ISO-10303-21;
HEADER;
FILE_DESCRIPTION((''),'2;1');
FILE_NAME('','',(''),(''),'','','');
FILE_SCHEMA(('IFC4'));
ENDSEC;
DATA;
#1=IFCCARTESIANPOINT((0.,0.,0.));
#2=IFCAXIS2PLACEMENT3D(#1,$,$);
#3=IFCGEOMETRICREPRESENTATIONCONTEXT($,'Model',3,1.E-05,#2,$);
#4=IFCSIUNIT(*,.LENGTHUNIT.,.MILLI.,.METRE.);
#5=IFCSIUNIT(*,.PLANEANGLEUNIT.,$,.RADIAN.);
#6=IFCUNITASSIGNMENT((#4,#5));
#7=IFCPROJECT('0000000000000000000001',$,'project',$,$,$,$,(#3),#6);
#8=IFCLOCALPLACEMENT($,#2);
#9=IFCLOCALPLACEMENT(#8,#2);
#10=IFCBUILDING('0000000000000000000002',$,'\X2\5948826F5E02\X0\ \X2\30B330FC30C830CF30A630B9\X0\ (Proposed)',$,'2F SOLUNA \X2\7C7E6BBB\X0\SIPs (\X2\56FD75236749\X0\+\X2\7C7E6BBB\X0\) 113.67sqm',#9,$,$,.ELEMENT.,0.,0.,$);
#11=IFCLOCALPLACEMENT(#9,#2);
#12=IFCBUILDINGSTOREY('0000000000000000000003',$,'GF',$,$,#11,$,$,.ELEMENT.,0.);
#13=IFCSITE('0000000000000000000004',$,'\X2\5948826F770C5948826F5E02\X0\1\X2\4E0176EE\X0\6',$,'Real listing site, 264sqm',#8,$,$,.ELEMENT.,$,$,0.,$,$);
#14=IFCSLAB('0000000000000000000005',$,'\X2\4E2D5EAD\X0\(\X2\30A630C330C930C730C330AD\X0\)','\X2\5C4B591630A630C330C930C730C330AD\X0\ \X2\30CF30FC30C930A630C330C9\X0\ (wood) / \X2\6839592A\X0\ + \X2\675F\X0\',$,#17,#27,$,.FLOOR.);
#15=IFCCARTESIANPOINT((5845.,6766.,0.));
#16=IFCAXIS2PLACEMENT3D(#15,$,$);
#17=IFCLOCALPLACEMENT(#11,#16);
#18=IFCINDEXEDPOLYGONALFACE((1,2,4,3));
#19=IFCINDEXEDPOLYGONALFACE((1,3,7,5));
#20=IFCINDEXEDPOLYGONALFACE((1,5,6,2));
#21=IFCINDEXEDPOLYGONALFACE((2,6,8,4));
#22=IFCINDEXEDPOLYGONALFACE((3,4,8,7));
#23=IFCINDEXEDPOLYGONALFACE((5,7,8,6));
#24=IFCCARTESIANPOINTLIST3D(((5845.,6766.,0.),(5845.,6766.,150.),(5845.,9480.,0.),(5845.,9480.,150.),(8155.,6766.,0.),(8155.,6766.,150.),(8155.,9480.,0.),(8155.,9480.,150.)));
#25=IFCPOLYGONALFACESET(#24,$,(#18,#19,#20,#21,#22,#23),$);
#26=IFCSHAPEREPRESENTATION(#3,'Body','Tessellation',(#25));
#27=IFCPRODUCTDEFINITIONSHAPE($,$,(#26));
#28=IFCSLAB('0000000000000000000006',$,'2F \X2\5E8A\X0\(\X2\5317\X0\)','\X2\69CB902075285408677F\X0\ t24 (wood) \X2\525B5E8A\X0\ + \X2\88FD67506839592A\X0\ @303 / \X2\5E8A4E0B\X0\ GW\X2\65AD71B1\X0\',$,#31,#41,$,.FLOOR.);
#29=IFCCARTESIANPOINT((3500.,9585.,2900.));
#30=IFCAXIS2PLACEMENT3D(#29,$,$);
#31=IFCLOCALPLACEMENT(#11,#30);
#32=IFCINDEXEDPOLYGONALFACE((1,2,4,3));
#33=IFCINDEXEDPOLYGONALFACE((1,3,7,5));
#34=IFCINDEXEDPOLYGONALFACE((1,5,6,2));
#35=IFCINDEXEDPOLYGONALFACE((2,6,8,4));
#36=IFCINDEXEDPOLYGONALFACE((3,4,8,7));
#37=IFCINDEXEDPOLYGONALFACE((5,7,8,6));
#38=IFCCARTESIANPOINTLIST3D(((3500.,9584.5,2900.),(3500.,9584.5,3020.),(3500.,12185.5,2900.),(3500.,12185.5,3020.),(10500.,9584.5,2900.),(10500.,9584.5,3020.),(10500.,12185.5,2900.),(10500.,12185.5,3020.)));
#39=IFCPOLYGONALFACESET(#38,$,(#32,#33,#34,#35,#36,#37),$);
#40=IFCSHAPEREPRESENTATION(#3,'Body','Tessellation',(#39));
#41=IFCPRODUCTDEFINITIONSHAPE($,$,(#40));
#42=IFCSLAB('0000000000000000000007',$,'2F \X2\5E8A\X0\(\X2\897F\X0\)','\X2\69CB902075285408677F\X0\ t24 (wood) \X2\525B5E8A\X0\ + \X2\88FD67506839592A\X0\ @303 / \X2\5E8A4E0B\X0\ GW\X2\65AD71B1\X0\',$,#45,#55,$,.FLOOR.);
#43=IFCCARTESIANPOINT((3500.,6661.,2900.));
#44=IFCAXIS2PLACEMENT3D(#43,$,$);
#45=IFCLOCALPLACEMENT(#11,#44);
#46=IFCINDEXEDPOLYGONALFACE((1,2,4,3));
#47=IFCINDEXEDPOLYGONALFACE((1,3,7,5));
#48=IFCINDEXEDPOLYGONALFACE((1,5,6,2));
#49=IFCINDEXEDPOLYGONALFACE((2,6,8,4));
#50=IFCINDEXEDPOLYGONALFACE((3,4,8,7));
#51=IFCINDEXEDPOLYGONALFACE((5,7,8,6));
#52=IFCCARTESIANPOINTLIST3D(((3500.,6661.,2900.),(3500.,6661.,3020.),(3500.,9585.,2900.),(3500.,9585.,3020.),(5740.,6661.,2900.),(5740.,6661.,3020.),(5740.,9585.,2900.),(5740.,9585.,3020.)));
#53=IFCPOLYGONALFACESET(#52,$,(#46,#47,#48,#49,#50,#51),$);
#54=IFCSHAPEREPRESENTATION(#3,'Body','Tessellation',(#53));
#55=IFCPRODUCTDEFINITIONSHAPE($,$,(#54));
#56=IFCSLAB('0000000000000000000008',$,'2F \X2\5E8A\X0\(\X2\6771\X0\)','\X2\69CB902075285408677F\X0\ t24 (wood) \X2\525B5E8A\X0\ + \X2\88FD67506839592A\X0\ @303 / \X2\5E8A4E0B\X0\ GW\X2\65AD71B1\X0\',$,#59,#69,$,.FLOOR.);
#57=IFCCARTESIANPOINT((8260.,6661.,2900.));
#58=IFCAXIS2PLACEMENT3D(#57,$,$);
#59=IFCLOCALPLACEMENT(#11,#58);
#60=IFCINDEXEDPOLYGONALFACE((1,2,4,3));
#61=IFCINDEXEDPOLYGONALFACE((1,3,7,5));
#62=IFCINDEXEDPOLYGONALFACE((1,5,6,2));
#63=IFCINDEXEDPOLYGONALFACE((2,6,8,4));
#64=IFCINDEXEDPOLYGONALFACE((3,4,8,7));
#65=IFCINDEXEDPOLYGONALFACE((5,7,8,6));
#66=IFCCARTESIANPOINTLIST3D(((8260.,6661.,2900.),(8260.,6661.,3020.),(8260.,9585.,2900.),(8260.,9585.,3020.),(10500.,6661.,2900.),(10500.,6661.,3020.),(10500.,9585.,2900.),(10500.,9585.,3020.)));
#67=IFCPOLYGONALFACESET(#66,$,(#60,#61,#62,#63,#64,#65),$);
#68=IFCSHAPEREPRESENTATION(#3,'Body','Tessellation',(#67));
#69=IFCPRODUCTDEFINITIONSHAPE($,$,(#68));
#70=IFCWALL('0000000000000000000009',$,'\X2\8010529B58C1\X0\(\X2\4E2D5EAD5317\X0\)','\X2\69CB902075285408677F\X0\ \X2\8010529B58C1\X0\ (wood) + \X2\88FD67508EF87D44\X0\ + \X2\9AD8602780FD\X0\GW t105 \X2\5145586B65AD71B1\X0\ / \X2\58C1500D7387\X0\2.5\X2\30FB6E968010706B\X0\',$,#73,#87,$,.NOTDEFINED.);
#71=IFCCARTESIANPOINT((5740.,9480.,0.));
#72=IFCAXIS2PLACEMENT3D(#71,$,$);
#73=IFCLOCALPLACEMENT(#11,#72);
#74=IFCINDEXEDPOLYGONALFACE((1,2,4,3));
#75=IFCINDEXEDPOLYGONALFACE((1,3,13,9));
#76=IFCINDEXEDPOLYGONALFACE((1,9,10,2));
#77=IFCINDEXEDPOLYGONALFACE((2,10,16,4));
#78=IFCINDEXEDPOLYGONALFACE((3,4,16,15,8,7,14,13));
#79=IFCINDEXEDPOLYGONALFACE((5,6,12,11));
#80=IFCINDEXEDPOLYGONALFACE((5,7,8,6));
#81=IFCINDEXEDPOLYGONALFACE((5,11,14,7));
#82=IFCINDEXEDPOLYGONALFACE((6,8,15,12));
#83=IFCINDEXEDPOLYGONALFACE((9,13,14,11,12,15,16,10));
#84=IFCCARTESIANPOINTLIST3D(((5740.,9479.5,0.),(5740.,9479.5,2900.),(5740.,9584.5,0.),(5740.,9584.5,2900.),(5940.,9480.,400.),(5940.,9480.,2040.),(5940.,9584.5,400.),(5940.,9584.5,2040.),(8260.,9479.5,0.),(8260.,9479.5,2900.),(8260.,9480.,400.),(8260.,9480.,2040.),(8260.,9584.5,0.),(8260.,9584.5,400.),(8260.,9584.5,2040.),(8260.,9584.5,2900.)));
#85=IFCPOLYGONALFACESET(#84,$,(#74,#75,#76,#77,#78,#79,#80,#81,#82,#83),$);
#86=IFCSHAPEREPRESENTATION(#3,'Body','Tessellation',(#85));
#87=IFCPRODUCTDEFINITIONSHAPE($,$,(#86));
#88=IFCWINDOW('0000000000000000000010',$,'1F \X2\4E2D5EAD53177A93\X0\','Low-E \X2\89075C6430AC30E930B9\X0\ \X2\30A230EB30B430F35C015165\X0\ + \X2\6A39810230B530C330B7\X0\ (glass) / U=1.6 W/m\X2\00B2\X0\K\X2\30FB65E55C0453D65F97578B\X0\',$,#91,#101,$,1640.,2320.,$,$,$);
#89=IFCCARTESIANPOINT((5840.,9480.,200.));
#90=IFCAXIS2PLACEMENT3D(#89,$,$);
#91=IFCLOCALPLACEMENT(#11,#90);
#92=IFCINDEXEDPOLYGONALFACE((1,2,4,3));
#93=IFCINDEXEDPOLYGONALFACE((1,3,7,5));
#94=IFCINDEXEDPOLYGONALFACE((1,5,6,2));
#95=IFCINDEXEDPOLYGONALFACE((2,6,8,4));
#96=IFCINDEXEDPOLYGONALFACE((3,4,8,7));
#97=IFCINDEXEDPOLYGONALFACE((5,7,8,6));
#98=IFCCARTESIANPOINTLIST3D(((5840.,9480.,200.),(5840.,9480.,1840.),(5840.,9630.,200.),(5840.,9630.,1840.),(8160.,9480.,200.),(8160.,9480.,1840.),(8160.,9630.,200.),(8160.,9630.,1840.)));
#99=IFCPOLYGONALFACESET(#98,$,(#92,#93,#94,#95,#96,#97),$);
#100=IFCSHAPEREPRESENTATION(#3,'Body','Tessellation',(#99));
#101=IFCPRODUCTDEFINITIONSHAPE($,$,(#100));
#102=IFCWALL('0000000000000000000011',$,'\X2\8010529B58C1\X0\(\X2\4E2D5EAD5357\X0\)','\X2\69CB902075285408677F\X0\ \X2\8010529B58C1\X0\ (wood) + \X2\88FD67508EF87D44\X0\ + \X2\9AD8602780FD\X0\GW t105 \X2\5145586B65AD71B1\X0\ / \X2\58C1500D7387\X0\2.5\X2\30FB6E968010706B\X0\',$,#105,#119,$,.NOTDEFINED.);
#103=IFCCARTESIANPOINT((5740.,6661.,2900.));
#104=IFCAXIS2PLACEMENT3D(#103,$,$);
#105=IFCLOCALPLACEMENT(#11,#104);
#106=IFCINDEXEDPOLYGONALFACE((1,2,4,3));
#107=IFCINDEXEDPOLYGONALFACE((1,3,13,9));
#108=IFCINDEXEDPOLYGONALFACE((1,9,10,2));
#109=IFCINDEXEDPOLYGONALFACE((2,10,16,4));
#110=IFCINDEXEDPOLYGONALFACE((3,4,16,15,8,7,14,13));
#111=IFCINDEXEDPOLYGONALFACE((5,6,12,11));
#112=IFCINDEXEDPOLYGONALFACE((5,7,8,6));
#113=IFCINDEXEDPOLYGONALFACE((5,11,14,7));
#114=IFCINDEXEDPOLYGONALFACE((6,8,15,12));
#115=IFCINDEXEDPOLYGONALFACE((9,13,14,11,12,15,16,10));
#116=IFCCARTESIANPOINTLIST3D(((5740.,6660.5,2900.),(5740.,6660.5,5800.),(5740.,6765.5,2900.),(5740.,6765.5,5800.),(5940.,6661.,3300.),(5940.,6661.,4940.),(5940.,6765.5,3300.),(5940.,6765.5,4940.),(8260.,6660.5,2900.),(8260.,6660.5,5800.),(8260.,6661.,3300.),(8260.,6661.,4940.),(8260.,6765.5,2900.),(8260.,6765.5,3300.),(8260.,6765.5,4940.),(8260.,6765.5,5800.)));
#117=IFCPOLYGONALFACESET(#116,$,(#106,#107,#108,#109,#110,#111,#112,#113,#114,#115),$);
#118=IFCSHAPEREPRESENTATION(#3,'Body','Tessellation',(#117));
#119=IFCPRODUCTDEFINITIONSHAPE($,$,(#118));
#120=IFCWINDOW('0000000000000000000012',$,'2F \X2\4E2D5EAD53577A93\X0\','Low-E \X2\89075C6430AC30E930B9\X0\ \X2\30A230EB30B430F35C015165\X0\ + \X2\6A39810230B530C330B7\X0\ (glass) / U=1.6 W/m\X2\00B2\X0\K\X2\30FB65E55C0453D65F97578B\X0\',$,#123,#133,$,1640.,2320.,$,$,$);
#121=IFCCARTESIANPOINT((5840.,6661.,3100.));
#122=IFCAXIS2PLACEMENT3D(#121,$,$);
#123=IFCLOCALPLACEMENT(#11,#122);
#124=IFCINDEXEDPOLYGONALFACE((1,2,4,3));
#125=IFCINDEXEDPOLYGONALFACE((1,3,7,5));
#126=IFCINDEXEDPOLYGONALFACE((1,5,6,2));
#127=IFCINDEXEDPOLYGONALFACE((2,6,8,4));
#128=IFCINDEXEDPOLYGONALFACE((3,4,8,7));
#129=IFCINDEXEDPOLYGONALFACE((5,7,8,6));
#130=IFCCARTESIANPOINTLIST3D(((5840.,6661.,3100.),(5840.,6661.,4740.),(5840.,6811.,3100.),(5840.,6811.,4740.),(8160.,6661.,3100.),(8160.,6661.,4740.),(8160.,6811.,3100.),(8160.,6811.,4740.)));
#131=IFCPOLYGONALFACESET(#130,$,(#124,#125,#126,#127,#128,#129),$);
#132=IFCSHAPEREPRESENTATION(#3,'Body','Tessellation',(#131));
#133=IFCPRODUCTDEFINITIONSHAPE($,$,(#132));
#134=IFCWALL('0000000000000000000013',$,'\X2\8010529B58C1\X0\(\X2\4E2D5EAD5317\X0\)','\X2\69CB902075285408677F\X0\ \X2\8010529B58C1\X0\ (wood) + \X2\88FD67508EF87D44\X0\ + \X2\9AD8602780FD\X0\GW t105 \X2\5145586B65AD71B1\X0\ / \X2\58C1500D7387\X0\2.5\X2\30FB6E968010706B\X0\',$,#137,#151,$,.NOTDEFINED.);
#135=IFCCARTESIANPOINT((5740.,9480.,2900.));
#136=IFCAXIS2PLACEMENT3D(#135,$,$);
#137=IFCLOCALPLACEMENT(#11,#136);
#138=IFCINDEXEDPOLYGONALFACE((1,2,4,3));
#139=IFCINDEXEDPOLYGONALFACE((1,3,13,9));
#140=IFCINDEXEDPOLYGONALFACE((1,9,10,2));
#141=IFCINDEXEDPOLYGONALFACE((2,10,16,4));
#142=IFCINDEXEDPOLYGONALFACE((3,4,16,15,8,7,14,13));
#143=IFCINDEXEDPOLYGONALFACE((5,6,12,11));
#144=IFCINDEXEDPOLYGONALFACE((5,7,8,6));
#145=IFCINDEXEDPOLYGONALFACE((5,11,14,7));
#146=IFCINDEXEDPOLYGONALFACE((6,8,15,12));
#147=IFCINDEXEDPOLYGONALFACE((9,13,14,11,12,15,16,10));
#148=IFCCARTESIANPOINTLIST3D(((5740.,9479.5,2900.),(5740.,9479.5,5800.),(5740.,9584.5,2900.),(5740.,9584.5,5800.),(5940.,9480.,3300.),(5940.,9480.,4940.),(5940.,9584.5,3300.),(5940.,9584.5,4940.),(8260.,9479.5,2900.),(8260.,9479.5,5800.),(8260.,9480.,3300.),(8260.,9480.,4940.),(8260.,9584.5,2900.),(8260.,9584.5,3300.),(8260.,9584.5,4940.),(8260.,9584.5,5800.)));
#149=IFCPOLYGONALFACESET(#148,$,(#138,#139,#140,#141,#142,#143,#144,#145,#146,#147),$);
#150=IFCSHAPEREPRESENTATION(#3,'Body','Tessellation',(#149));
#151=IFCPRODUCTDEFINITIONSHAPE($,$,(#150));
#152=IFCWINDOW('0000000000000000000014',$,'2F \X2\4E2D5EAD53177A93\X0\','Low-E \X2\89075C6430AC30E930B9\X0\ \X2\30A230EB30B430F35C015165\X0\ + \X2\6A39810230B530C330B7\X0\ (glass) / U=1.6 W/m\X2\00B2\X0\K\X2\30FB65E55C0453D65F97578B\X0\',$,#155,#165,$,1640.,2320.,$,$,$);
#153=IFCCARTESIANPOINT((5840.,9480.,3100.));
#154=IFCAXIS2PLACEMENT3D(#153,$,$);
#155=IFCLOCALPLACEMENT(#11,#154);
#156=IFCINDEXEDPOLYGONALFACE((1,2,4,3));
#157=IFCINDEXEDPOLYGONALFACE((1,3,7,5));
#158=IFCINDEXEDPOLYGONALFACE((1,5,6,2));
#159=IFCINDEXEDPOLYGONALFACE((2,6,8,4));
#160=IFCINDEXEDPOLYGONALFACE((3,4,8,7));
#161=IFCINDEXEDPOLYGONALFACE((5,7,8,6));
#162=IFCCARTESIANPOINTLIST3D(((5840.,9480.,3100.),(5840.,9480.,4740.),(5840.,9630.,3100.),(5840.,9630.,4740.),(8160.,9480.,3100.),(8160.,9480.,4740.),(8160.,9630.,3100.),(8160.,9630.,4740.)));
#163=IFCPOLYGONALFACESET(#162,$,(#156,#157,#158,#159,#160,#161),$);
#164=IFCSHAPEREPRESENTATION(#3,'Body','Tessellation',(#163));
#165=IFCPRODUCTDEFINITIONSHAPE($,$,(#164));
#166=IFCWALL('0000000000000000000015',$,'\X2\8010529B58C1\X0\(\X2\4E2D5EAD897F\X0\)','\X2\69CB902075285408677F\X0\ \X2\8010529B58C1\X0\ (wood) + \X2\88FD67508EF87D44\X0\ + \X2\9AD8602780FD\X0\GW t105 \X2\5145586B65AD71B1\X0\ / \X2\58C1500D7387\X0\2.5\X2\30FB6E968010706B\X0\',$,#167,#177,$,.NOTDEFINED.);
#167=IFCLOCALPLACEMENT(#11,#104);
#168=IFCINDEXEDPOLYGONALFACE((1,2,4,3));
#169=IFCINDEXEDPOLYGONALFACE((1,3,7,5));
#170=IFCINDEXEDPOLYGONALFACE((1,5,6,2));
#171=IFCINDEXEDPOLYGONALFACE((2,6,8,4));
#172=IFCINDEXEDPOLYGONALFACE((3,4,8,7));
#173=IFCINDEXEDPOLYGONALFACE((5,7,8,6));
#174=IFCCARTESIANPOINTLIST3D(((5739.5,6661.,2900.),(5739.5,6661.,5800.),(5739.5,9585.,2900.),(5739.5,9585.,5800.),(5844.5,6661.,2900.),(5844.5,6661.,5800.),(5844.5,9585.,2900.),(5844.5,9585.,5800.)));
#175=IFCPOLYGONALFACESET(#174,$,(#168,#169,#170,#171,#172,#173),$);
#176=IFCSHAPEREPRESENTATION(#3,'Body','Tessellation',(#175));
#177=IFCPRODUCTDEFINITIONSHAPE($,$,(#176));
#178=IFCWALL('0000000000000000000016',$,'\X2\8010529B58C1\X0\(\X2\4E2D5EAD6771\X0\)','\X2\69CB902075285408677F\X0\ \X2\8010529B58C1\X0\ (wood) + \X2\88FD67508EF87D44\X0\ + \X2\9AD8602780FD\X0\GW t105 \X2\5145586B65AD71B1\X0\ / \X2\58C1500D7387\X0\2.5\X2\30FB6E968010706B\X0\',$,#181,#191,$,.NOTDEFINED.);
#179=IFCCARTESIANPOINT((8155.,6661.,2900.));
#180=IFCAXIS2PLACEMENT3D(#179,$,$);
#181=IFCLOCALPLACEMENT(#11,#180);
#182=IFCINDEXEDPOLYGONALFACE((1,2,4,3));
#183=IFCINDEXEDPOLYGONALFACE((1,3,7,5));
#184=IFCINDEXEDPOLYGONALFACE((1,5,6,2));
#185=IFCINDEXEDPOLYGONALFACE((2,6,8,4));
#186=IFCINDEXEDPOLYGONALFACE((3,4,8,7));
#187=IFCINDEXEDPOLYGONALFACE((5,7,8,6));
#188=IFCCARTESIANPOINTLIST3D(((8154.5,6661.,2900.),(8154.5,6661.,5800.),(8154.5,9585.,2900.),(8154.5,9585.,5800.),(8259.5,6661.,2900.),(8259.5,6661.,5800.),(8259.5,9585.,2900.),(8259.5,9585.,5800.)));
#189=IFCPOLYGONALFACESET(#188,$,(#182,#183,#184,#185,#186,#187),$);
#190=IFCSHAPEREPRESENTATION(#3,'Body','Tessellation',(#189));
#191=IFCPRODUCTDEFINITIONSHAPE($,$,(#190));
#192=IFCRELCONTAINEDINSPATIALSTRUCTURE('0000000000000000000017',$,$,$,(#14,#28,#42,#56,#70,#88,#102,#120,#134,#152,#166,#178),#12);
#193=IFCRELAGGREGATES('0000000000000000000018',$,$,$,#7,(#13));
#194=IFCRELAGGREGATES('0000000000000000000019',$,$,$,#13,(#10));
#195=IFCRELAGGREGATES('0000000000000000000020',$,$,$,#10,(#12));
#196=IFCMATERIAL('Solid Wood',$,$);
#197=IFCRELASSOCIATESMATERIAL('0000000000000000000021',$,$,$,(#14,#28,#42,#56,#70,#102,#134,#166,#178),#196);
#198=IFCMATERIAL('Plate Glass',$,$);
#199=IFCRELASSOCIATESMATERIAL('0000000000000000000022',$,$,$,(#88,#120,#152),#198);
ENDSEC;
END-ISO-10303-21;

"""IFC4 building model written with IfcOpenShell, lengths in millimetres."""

from ifc_helpers import new_model, si_unit, frame, frame_2d, origin, place, context, project, spatial, rectangle, extrude, material, element, fill, save


model = new_model("IFC4")

# Units and contexts
model_context = context("Model", 3, precision=1e-05, world=origin())
ifc_project = project(units=[si_unit("LENGTHUNIT", "METRE", prefix="MILLI"), si_unit("PLANEANGLEUNIT", "RADIAN")], contexts=[model_context])

# Site, building, storey
site_placement = place(None, origin())
site = spatial("IfcSite", under=ifc_project, at=site_placement, Name="奈良県奈良市1丁目6", ObjectType="Real listing site, 264sqm", CompositionType="ELEMENT", RefElevation=0.0)
building_placement = place(site_placement, origin())
building = spatial("IfcBuilding", under=site, at=building_placement, Name="奈良市 コートハウス (Proposed)", ObjectType="2F SOLUNA 籾殻SIPs (国産杉+籾殻) 113.67sqm", CompositionType="ELEMENT", ElevationOfRefHeight=0.0, ElevationOfTerrain=0.0)
storey_placement = place(building_placement, origin())
storey = spatial("IfcBuildingStorey", under=building, at=storey_placement, Name="GF", CompositionType="ELEMENT", Elevation=0.0)

# Slabs
ifc_material_1 = material(Name="Solid Wood")
slab_1_placement = place(storey_placement, frame((5845.0, 6766.0, 0.0)))
element("IfcSlab", 1, at=slab_1_placement, inside=storey, material=ifc_material_1, Name="中庭(ウッドデッキ)", Description="屋外ウッドデッキ ハードウッド (wood) / 根太 + 束", PredefinedType="FLOOR", context=model_context, shape_type="SweptSolid", body=[
    extrude(rectangle(XDim=2310.0, YDim=2714.0, at=frame_2d((1155.0, 1357.0))), frame((5845.0, 6766.0, 0.0)), (0.0, 0.0, 1.0), 150.0),
])
slab_2_placement = place(storey_placement, frame((3500.0, 9585.0, 2900.0)))
element("IfcSlab", 2, at=slab_2_placement, inside=storey, material=ifc_material_1, Name="2F 床(北)", Description="構造用合板 t24 (wood) 剛床 + 製材根太 @303 / 床下 GW断熱", PredefinedType="FLOOR", context=model_context, shape_type="SweptSolid", body=[
    extrude(rectangle(XDim=7000.0, YDim=2601.0, at=frame_2d((3500.0, 1300.0))), frame((3500.0, 9585.0, 2900.0)), (0.0, 0.0, 1.0), 120.0),
])
slab_3_placement = place(storey_placement, frame((3500.0, 6661.0, 2900.0)))
element("IfcSlab", 3, at=slab_3_placement, inside=storey, material=ifc_material_1, Name="2F 床(西)", Description="構造用合板 t24 (wood) 剛床 + 製材根太 @303 / 床下 GW断熱", PredefinedType="FLOOR", context=model_context, shape_type="SweptSolid", body=[
    extrude(rectangle(XDim=2240.0, YDim=2924.0, at=frame_2d((1120.0, 1462.0))), frame((3500.0, 6661.0, 2900.0)), (0.0, 0.0, 1.0), 120.0),
])
slab_4_placement = place(storey_placement, frame((8260.0, 6661.0, 2900.0)))
element("IfcSlab", 4, at=slab_4_placement, inside=storey, material=ifc_material_1, Name="2F 床(東)", Description="構造用合板 t24 (wood) 剛床 + 製材根太 @303 / 床下 GW断熱", PredefinedType="FLOOR", context=model_context, shape_type="SweptSolid", body=[
    extrude(rectangle(XDim=2240.0, YDim=2924.0, at=frame_2d((1120.0, 1462.0))), frame((8260.0, 6661.0, 2900.0)), (0.0, 0.0, 1.0), 120.0),
])

# Wall, opening, window
wall_1_placement = place(storey_placement, frame((5740.0, 9480.0, 0.0)))
wall_1 = element("IfcWall", 5, at=wall_1_placement, inside=storey, material=ifc_material_1, Name="耐力壁(中庭北)", Description="構造用合板 耐力壁 (wood) + 製材軸組 + 高性能GW t105 充填断熱 / 壁倍率2.5・準耐火", PredefinedType="NOTDEFINED", context=model_context, shape_type="SweptSolid", body=[
    extrude(rectangle(XDim=2520.0, YDim=105.0, at=frame_2d((1260.0, 52.0))), frame((5740.0, 9480.0, 0.0)), (0.0, 0.0, 1.0), 2900.0),
])
opening_1_placement = place(storey_placement, frame((5840.0, 9480.0, 200.0)))
opening_1 = element("IfcOpeningElement", 6, at=opening_1_placement, cuts=wall_1, PredefinedType="NOTDEFINED", context=model_context, shape_type="SweptSolid", body=[
    extrude(rectangle(XDim=2320.0, YDim=150.0, at=frame_2d((1160.0, 75.0))), frame((5840.0, 9480.0, 200.0)), (0.0, 0.0, 1.0), 1640.0),
])
ifc_material_2 = material(Name="Plate Glass")
window_1_placement = place(storey_placement, frame((5840.0, 9480.0, 200.0)))
window_1 = element("IfcWindow", 7, at=window_1_placement, inside=storey, material=ifc_material_2, Name="1F 中庭北窓", Description="Low-E 複層ガラス アルゴン封入 + 樹脂サッシ (glass) / U=1.6 W/m²K・日射取得型", OverallHeight=1640.0, OverallWidth=2320.0, context=model_context, shape_type="SweptSolid", body=[
    extrude(rectangle(XDim=2320.0, YDim=150.0, at=frame_2d((1160.0, 75.0))), frame((5840.0, 9480.0, 200.0)), (0.0, 0.0, 1.0), 1640.0),
])
fill(opening_1, window_1)

# Walls, openings, windows
wall_2_placement = place(storey_placement, frame((5740.0, 6661.0, 2900.0)))
wall_2 = element("IfcWall", 8, at=wall_2_placement, inside=storey, material=ifc_material_1, Name="耐力壁(中庭南)", Description="構造用合板 耐力壁 (wood) + 製材軸組 + 高性能GW t105 充填断熱 / 壁倍率2.5・準耐火", PredefinedType="NOTDEFINED", context=model_context, shape_type="SweptSolid", body=[
    extrude(rectangle(XDim=2520.0, YDim=105.0, at=frame_2d((1260.0, 52.0))), frame((5740.0, 6661.0, 2900.0)), (0.0, 0.0, 1.0), 2900.0),
])
opening_2_placement = place(storey_placement, frame((5840.0, 6661.0, 3100.0)))
opening_2 = element("IfcOpeningElement", 9, at=opening_2_placement, cuts=wall_2, PredefinedType="NOTDEFINED", context=model_context, shape_type="SweptSolid", body=[
    extrude(rectangle(XDim=2320.0, YDim=150.0, at=frame_2d((1160.0, 75.0))), frame((5840.0, 6661.0, 3100.0)), (0.0, 0.0, 1.0), 1640.0),
])
window_2_placement = place(storey_placement, frame((5840.0, 6661.0, 3100.0)))
window_2 = element("IfcWindow", 10, at=window_2_placement, inside=storey, material=ifc_material_2, Name="2F 中庭南窓", Description="Low-E 複層ガラス アルゴン封入 + 樹脂サッシ (glass) / U=1.6 W/m²K・日射取得型", OverallHeight=1640.0, OverallWidth=2320.0, context=model_context, shape_type="SweptSolid", body=[
    extrude(rectangle(XDim=2320.0, YDim=150.0, at=frame_2d((1160.0, 75.0))), frame((5840.0, 6661.0, 3100.0)), (0.0, 0.0, 1.0), 1640.0),
])
fill(opening_2, window_2)
wall_3_placement = place(storey_placement, frame((5740.0, 9480.0, 2900.0)))
wall_3 = element("IfcWall", 11, at=wall_3_placement, inside=storey, material=ifc_material_1, Name="耐力壁(中庭北)", Description="構造用合板 耐力壁 (wood) + 製材軸組 + 高性能GW t105 充填断熱 / 壁倍率2.5・準耐火", PredefinedType="NOTDEFINED", context=model_context, shape_type="SweptSolid", body=[
    extrude(rectangle(XDim=2520.0, YDim=105.0, at=frame_2d((1260.0, 52.0))), frame((5740.0, 9480.0, 2900.0)), (0.0, 0.0, 1.0), 2900.0),
])
opening_3_placement = place(storey_placement, frame((5840.0, 9480.0, 3100.0)))
opening_3 = element("IfcOpeningElement", 12, at=opening_3_placement, cuts=wall_3, PredefinedType="NOTDEFINED", context=model_context, shape_type="SweptSolid", body=[
    extrude(rectangle(XDim=2320.0, YDim=150.0, at=frame_2d((1160.0, 75.0))), frame((5840.0, 9480.0, 3100.0)), (0.0, 0.0, 1.0), 1640.0),
])
window_3_placement = place(storey_placement, frame((5840.0, 9480.0, 3100.0)))
window_3 = element("IfcWindow", 13, at=window_3_placement, inside=storey, material=ifc_material_2, Name="2F 中庭北窓", Description="Low-E 複層ガラス アルゴン封入 + 樹脂サッシ (glass) / U=1.6 W/m²K・日射取得型", OverallHeight=1640.0, OverallWidth=2320.0, context=model_context, shape_type="SweptSolid", body=[
    extrude(rectangle(XDim=2320.0, YDim=150.0, at=frame_2d((1160.0, 75.0))), frame((5840.0, 9480.0, 3100.0)), (0.0, 0.0, 1.0), 1640.0),
])
fill(opening_3, window_3)

# Walls
wall_4_placement = place(storey_placement, frame((5740.0, 6661.0, 2900.0)))
element("IfcWall", 14, at=wall_4_placement, inside=storey, material=ifc_material_1, Name="耐力壁(中庭西)", Description="構造用合板 耐力壁 (wood) + 製材軸組 + 高性能GW t105 充填断熱 / 壁倍率2.5・準耐火", PredefinedType="NOTDEFINED", context=model_context, shape_type="SweptSolid", body=[
    extrude(rectangle(XDim=105.0, YDim=2924.0, at=frame_2d((52.0, 1462.0))), frame((5740.0, 6661.0, 2900.0)), (0.0, 0.0, 1.0), 2900.0),
])
wall_5_placement = place(storey_placement, frame((8155.0, 6661.0, 2900.0)))
element("IfcWall", 15, at=wall_5_placement, inside=storey, material=ifc_material_1, Name="耐力壁(中庭東)", Description="構造用合板 耐力壁 (wood) + 製材軸組 + 高性能GW t105 充填断熱 / 壁倍率2.5・準耐火", PredefinedType="NOTDEFINED", context=model_context, shape_type="SweptSolid", body=[
    extrude(rectangle(XDim=105.0, YDim=2924.0, at=frame_2d((52.0, 1462.0))), frame((8155.0, 6661.0, 2900.0)), (0.0, 0.0, 1.0), 2900.0),
])

save(model, "model.ifc")
